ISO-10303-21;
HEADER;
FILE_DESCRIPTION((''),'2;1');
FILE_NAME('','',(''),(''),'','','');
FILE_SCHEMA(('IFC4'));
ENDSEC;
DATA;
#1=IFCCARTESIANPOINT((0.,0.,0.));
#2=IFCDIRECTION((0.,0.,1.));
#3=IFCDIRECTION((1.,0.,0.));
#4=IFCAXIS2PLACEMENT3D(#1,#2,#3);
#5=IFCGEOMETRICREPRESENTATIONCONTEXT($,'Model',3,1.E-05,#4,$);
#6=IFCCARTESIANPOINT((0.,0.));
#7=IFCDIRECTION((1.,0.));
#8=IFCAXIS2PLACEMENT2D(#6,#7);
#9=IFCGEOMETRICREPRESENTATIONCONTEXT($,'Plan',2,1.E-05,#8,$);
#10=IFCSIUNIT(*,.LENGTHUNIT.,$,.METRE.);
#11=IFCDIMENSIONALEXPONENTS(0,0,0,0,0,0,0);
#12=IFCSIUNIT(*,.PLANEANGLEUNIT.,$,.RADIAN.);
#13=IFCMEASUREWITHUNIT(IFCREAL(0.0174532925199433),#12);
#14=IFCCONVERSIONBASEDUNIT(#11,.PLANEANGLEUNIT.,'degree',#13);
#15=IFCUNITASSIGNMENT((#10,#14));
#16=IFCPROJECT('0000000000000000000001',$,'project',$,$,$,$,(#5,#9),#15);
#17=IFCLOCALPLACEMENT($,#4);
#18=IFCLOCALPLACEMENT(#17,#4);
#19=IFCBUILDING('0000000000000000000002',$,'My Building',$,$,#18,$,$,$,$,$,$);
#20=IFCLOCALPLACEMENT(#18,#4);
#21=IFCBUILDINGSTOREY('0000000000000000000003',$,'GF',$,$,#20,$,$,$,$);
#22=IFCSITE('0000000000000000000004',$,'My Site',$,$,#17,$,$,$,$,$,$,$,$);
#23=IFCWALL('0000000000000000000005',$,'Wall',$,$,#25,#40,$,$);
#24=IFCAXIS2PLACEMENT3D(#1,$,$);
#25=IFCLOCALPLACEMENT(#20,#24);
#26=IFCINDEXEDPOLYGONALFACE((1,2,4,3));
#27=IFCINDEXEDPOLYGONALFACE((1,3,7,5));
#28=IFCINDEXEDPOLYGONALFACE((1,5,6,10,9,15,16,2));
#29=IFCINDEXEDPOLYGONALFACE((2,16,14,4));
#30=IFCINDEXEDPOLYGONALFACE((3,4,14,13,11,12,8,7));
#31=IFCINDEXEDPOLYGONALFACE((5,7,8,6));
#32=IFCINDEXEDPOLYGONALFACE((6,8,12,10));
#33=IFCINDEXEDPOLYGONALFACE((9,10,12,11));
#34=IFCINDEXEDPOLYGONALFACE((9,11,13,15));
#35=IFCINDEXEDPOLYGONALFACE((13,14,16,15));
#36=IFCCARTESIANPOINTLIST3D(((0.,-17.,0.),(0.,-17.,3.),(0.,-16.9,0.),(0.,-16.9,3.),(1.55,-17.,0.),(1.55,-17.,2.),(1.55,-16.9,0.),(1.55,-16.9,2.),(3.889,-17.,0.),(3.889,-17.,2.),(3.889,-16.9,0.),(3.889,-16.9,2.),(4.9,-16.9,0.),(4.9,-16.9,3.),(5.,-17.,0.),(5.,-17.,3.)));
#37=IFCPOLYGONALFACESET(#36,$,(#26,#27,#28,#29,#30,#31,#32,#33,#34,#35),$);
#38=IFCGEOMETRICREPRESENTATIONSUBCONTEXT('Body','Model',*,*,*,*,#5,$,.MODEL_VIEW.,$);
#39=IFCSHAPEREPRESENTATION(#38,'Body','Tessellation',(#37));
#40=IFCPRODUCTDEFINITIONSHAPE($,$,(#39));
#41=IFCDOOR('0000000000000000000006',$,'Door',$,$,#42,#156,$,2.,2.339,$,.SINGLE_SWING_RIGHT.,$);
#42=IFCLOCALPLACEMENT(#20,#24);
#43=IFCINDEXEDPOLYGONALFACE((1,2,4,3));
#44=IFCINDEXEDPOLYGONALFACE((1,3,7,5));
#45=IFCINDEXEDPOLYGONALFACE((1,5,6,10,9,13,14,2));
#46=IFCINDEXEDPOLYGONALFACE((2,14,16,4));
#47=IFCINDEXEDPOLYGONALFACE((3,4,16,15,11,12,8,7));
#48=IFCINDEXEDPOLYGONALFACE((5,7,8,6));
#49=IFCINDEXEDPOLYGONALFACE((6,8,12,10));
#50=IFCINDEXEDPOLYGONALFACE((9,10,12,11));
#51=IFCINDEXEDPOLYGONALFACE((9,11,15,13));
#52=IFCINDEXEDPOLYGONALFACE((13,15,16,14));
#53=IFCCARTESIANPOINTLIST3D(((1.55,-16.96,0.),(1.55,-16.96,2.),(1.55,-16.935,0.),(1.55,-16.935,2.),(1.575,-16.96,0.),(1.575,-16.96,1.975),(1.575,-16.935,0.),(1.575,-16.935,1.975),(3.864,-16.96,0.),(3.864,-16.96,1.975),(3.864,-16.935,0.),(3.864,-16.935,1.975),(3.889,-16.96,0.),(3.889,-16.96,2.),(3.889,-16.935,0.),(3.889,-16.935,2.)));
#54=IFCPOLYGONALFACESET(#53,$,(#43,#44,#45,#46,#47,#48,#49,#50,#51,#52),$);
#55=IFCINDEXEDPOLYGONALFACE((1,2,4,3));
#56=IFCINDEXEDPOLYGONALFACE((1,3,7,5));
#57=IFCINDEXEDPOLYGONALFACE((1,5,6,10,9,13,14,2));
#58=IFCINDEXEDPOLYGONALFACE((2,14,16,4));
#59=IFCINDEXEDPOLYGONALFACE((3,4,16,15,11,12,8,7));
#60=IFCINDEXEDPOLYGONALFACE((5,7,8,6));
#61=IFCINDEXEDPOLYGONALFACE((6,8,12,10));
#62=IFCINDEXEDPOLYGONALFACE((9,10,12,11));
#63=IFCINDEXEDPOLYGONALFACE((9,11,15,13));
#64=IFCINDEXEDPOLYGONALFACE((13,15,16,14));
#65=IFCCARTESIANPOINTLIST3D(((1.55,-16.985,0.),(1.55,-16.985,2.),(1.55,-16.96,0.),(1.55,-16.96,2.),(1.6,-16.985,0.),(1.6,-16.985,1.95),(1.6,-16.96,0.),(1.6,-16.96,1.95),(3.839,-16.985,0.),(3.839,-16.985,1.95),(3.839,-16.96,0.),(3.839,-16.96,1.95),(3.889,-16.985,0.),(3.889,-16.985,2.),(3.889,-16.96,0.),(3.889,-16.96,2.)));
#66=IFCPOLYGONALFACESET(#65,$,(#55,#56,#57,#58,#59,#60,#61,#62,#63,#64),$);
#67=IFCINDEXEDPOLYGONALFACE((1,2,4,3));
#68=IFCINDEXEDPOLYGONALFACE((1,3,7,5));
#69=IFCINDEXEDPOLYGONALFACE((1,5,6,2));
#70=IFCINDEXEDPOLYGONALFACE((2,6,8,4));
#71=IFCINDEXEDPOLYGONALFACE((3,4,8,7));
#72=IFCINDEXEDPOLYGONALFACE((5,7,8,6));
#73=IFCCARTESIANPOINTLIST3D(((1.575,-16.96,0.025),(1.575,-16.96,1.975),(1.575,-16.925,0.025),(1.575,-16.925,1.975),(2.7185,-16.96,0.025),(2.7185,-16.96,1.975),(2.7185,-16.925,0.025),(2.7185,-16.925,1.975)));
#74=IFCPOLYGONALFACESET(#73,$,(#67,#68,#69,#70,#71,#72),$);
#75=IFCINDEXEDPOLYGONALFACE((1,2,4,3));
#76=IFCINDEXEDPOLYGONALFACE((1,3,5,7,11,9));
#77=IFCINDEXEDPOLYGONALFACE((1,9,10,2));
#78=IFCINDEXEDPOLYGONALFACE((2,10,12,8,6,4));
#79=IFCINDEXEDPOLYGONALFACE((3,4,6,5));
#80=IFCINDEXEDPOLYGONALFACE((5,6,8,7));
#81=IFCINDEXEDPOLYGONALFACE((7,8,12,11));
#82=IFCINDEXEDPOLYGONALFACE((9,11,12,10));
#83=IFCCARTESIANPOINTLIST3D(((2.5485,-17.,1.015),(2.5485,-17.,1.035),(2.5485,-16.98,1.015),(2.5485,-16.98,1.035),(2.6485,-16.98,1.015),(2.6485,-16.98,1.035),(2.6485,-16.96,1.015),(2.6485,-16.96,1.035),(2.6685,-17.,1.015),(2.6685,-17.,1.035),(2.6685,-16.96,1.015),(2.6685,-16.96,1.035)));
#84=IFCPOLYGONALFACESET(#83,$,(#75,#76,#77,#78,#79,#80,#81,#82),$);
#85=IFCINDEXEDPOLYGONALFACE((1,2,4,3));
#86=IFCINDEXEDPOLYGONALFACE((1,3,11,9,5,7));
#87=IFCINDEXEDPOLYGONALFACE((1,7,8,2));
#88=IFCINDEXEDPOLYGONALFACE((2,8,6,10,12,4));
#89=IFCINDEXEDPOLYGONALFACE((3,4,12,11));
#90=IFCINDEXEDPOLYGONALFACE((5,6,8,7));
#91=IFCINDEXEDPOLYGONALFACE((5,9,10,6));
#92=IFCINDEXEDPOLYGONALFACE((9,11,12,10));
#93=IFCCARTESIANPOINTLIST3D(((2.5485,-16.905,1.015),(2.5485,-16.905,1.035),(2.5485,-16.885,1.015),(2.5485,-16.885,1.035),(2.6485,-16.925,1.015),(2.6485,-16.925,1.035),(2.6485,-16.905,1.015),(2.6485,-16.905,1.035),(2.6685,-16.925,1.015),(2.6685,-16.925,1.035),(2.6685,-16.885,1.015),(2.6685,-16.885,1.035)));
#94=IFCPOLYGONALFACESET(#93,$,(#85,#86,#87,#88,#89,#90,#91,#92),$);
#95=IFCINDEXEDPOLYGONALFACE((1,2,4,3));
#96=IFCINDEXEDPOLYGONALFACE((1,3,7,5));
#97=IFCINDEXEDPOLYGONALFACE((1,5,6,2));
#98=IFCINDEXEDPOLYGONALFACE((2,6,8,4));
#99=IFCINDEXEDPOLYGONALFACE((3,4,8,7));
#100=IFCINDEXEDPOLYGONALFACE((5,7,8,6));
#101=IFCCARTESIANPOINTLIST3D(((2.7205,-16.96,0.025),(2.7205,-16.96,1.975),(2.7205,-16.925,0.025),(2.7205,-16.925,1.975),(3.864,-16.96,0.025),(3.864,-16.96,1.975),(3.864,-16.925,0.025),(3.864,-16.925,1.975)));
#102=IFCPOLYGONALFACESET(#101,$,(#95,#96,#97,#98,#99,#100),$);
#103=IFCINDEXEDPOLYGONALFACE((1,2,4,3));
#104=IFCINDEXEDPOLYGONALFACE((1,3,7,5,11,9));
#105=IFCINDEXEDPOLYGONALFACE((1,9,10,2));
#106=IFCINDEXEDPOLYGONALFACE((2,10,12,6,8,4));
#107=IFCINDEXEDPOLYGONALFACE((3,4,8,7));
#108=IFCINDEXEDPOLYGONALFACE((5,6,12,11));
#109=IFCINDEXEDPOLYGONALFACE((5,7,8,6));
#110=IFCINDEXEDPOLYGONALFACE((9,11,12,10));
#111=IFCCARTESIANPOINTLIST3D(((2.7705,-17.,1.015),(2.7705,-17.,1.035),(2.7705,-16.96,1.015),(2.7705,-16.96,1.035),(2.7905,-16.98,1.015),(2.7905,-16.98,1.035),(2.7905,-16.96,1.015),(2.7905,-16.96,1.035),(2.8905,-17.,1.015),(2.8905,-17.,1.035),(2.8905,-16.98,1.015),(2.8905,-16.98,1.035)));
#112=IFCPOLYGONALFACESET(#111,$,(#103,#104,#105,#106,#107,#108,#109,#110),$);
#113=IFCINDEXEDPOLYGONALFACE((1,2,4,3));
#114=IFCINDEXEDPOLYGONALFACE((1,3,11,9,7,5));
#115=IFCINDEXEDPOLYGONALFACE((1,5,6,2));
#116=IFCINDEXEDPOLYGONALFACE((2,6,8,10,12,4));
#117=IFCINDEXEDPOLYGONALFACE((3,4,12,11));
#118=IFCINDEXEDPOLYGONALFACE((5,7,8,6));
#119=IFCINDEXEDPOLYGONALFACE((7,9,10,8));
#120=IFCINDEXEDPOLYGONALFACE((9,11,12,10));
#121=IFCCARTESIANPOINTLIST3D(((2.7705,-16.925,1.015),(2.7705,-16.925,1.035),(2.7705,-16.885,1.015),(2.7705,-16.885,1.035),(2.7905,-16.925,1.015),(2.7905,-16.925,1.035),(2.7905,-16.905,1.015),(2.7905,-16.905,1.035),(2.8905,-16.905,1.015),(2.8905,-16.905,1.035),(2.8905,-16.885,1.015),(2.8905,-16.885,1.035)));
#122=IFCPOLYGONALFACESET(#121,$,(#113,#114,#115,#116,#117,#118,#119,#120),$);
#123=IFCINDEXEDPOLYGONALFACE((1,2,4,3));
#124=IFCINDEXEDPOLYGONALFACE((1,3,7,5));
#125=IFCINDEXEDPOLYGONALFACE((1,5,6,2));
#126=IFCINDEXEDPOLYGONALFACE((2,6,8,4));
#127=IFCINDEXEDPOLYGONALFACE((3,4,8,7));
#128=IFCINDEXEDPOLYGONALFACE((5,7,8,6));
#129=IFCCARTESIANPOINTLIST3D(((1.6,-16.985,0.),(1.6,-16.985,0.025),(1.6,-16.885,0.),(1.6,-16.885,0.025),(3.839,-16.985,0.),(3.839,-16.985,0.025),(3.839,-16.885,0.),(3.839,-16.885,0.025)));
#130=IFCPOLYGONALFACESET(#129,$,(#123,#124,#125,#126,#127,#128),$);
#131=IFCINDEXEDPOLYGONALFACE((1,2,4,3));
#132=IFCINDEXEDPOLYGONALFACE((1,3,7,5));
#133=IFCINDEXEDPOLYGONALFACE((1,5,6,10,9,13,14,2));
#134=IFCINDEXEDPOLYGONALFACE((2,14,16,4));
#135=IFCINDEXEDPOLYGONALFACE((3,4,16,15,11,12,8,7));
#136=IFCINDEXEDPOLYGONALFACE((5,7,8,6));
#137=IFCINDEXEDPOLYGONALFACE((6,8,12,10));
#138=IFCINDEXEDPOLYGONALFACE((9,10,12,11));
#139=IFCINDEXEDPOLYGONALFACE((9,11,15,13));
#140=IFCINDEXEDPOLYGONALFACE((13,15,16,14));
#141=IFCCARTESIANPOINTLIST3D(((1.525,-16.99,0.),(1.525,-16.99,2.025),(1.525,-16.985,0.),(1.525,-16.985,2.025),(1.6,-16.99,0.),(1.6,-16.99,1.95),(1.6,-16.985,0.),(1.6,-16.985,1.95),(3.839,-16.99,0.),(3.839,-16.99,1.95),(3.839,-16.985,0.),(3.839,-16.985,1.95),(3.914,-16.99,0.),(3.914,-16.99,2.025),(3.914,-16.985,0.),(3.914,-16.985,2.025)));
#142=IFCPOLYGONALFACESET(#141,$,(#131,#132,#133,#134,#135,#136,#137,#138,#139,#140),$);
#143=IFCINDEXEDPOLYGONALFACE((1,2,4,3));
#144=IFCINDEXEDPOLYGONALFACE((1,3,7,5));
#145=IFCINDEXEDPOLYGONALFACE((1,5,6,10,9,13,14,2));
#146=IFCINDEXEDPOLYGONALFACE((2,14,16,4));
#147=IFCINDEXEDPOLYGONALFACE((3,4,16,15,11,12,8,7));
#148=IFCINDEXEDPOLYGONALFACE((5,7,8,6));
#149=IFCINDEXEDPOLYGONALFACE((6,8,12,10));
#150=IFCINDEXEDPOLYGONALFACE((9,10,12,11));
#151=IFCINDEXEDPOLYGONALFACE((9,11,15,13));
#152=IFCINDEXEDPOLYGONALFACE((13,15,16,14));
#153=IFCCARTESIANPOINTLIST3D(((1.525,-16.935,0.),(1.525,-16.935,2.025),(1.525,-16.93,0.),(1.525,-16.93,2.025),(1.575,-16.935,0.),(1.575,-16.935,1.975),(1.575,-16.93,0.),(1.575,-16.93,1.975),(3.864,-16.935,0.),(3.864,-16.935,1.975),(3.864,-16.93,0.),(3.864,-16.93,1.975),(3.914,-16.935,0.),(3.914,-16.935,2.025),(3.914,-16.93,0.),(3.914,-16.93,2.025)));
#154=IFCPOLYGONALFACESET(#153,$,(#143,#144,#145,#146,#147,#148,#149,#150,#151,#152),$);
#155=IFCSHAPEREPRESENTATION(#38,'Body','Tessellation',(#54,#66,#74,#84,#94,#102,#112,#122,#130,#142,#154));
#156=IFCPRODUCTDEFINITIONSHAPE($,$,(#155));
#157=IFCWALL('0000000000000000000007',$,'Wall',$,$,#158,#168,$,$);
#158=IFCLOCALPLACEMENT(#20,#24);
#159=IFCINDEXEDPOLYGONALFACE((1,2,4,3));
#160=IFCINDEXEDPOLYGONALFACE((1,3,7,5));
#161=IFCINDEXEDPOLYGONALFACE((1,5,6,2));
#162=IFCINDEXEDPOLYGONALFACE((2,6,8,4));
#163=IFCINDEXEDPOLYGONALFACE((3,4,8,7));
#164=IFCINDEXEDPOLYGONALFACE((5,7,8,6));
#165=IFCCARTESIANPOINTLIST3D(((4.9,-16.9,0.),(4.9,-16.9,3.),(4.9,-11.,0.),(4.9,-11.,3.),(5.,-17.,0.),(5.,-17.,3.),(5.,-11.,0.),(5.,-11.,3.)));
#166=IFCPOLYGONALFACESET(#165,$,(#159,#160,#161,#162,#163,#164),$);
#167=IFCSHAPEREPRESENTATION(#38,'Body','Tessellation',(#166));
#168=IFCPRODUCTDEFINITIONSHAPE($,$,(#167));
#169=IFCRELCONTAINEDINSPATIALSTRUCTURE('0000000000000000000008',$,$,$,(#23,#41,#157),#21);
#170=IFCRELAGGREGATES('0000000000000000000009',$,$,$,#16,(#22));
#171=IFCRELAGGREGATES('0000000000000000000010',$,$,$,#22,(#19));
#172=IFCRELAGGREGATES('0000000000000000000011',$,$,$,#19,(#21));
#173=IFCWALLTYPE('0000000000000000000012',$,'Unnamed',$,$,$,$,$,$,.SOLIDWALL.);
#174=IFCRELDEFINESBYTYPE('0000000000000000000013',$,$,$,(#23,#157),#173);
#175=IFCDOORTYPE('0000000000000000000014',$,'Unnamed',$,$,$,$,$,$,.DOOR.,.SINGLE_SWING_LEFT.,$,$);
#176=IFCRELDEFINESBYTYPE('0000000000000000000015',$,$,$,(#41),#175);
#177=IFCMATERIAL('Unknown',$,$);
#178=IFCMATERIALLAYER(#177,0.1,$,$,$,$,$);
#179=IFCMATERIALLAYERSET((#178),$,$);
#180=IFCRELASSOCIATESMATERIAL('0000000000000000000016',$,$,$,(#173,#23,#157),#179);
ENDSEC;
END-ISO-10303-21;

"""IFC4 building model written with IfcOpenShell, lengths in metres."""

from ifc_helpers import new_model, entity, si_unit, converted_unit, frame, origin_with_axes, origin_2d_with_axis, place, context, subcontext, project, spatial, line, indexed_curve, outline, extrude, shape, source, transform, mapped, material, layer, layer_set, layer_usage, type_object, type_shapes, element, fill, save


model = new_model("IFC4")

# Units and contexts
model_context = context("Model", 3, precision=1e-05, world=origin_with_axes())
plan_context = context("Plan", 2, precision=1e-05, world=origin_2d_with_axis())
body_context_1 = subcontext(model_context, "Body", "Model", "MODEL_VIEW")
body_context_2 = subcontext(plan_context, "Body", "Plan", "PLAN_VIEW")
ifc_project = project(units=[si_unit("LENGTHUNIT", "METRE"), converted_unit("PLANEANGLEUNIT", "degree", entity("IfcReal", 0.0174532925199433), si_unit("PLANEANGLEUNIT", "RADIAN"), dimensions=[0, 0, 0, 0, 0, 0, 0])], contexts=[model_context, plan_context])

# Site, building, storey
site_placement = place(None, origin_with_axes())
site = spatial("IfcSite", under=ifc_project, at=site_placement, Name="My Site")
building_placement = place(site_placement, origin_with_axes())
building = spatial("IfcBuilding", under=site, at=building_placement, Name="My Building")
storey_placement = place(building_placement, origin_with_axes())
storey = spatial("IfcBuildingStorey", under=building, at=storey_placement, Name="GF")

# Shared definitions
ifc_material = material(Name="Unknown")

# Shared definitions
ifc_layer_1 = layer(ifc_material, 0.1)
ifc_layer_set_1 = layer_set([ifc_layer_1])
wall_type = type_object("IfcWallType", Name="Unnamed", PredefinedType="SOLIDWALL", material=ifc_layer_set_1)

# Wall, opening, door
ifc_layer_usage_1 = layer_usage(ifc_layer_set_1, "AXIS2", "POSITIVE", 0.0)
wall_1_placement = place(storey_placement, frame((0.0, -17.0, 0.0), z_axis=(0.0, 0.0, 1.0), x_axis=(1.0, 0.0, 0.0)))
wall_1 = element("IfcWall", 1, at=wall_1_placement, inside=storey, type_object=wall_type, material=ifc_layer_usage_1, Name="Wall", context=body_context_1, shape_type="SweptSolid", body=[
    extrude(outline(indexed_curve([(0.0, 0.0), (0.0, 0.1), (4.9, 0.1), (5.0, 0.0)], segments=[line(1, 2, 3, 4, 1)])), origin_with_axes(), (0.0, 0.0, 1.0), 3.0),
])
shared_shape_1 = source(origin_with_axes(), body_context_1, "Body", "SweptSolid", [
    extrude(outline(indexed_curve([(0.0, 0.0), (2.339, 0.0), (2.339, 2.0), (0.0, 2.0)], segments=[line(1, 2, 3, 4, 1)])), frame((0.0, -0.6, 0.0), z_axis=(0.0, -1.0, 0.0), x_axis=(1.0, 0.0, 0.0)), (0.0, 0.0, -1.0), 1.2),
])
opening_1_placement = place(wall_1_placement, frame((1.55, 0.015, 0.0), z_axis=(0.0, 0.0, 1.0), x_axis=(1.0, 0.0, 0.0)))
opening_1 = element("IfcOpeningElement", 2, at=opening_1_placement, cuts=wall_1, PredefinedType="OPENING", context=body_context_1, shape_type="MappedRepresentation", body=[
    mapped(shared_shape_1, transform((0.0, 0.0, 0.0), x_axis=(1.0, 0.0, 0.0), y_axis=(0.0, 1.0, 0.0), z_axis=(0.0, 0.0, 1.0), scale=1.0)),
])
door_type_1 = type_object("IfcDoorType", Name="Unnamed", OperationType="SINGLE_SWING_LEFT", PredefinedType="DOOR")
shared_shape_2 = source(origin_with_axes(), body_context_1, "Body", "SweptSolid", [
    extrude(outline(indexed_curve([(0.0, 0.0), (0.0, 2.0), (2.339, 2.0), (2.339, 0.0), (2.314, 0.0), (2.314, 1.975), (0.025, 1.975), (0.025, 0.0)], segments=[line(1, 2, 3, 4, 5, 6, 7, 8, 1)])), frame((0.0, 0.025, 0.0), z_axis=(0.0, -1.0, 0.0), x_axis=(1.0, 0.0, 0.0)), (0.0, 0.0, -1.0), 0.025),
    extrude(outline(indexed_curve([(0.0, 0.0), (0.0, 2.0), (2.339, 2.0), (2.339, 0.0), (2.289, 0.0), (2.289, 1.95), (0.05, 1.95), (0.05, 0.0)], segments=[line(1, 2, 3, 4, 5, 6, 7, 8, 1)])), frame((0.0, 0.0, 0.0), z_axis=(0.0, -1.0, 0.0), x_axis=(1.0, 0.0, 0.0)), (0.0, 0.0, -1.0), 0.025),
    extrude(outline(indexed_curve([(0.0, 0.0), (1.1435, 0.0), (1.1435, 0.035), (0.0, 0.035)], segments=[line(1, 2, 3, 4, 1)])), frame((0.025, 0.025, 0.025), z_axis=(0.0, 0.0, 1.0), x_axis=(1.0, 0.0, 0.0)), (0.0, 0.0, 1.0), 1.95),
    extrude(outline(indexed_curve([(0.0, 0.0), (0.0, -0.04), (-0.12, -0.04), (-0.12, -0.02), (-0.02, -0.02), (-0.02, 0.0)], segments=[line(1, 2, 3, 4, 5, 6, 1)])), frame((1.1185, 0.025, 1.015), z_axis=(0.0, 0.0, 1.0), x_axis=(1.0, 0.0, 0.0)), (0.0, 0.0, 1.0), 0.02),
    extrude(outline(indexed_curve([(0.0, 0.0), (0.0, 0.04), (-0.12, 0.04), (-0.12, 0.02), (-0.02, 0.02), (-0.02, 0.0)], segments=[line(1, 2, 3, 4, 5, 6, 1)])), frame((1.1185, 0.06, 1.015), z_axis=(0.0, 0.0, 1.0), x_axis=(1.0, 0.0, 0.0)), (0.0, 0.0, 1.0), 0.02),
    extrude(outline(indexed_curve([(0.0, 0.0), (-1.1435, 0.0), (-1.1435, 0.035), (0.0, 0.035)], segments=[line(1, 2, 3, 4, 1)])), frame((2.314, 0.025, 0.025), z_axis=(0.0, 0.0, 1.0), x_axis=(1.0, 0.0, 0.0)), (0.0, 0.0, 1.0), 1.95),
    extrude(outline(indexed_curve([(0.0, 0.0), (0.0, -0.04), (0.12, -0.04), (0.12, -0.02), (0.02, -0.02), (0.02, 0.0)], segments=[line(1, 2, 3, 4, 5, 6, 1)])), frame((1.2205, 0.025, 1.015), z_axis=(0.0, 0.0, 1.0), x_axis=(1.0, 0.0, 0.0)), (0.0, 0.0, 1.0), 0.02),
    extrude(outline(indexed_curve([(0.0, 0.0), (0.0, 0.04), (0.12, 0.04), (0.12, 0.02), (0.02, 0.02), (0.02, 0.0)], segments=[line(1, 2, 3, 4, 5, 6, 1)])), frame((1.2205, 0.06, 1.015), z_axis=(0.0, 0.0, 1.0), x_axis=(1.0, 0.0, 0.0)), (0.0, 0.0, 1.0), 0.02),
    extrude(outline(indexed_curve([(0.0, 0.0), (2.239, 0.0), (2.239, 0.1), (0.0, 0.1)], segments=[line(1, 2, 3, 4, 1)])), frame((0.05, 0.0, 0.0), z_axis=(0.0, 0.0, 1.0), x_axis=(1.0, 0.0, 0.0)), (0.0, 0.0, 1.0), 0.025),
    extrude(outline(indexed_curve([(0.0, 0.0), (0.0, 2.025), (2.389, 2.025), (2.389, 0.0), (2.314, 0.0), (2.314, 1.95), (0.075, 1.95), (0.075, 0.0)], segments=[line(1, 2, 3, 4, 5, 6, 7, 8, 1)])), frame((-0.025, -0.005, 0.0), z_axis=(0.0, -1.0, 0.0), x_axis=(1.0, 0.0, 0.0)), (0.0, 0.0, -1.0), 0.005),
    extrude(outline(indexed_curve([(0.0, 0.0), (0.0, 2.025), (2.389, 2.025), (2.389, 0.0), (2.339, 0.0), (2.339, 1.975), (0.05, 1.975), (0.05, 0.0)], segments=[line(1, 2, 3, 4, 5, 6, 7, 8, 1)])), frame((-0.025, 0.05, 0.0), z_axis=(0.0, -1.0, 0.0), x_axis=(1.0, 0.0, 0.0)), (0.0, 0.0, -1.0), 0.005),
])
shared_shape_3 = source(origin_with_axes(), body_context_2, "Body", "Curve2D", [
    entity("IfcIndexedPolyCurve", entity("IfcCartesianPointList2D", [[0.0, 0.0], [0.0, 0.05], [0.025, 0.05], [0.025, 0.025], [0.05, 0.025], [0.05, 0.0]]), [entity("IfcLineIndex", [1, 2, 3, 4, 5, 6, 1])]),
    entity("IfcIndexedPolyCurve", entity("IfcCartesianPointList2D", [[2.339, 0.0], [2.339, 0.05], [2.314, 0.05], [2.314, 0.025], [2.289, 0.025], [2.289, 0.0]]), [entity("IfcLineIndex", [1, 2, 3, 4, 5, 6, 1])]),
    entity("IfcTrimmedCurve", entity("IfcEllipse", entity("IfcAxis2Placement2D", entity("IfcCartesianPoint", [0.06, 0.05]), entity("IfcDirection", [1.0, 0.0])), 1.1095, 1.1445), [entity("IfcCartesianPoint", [1.1695, 0.05])], [entity("IfcCartesianPoint", [0.06, 1.1945])], True, "CARTESIAN"),
    entity("IfcIndexedPolyCurve", entity("IfcCartesianPointList2D", [[0.025, 0.05], [0.06, 0.05], [0.06, 1.1945], [0.025, 1.1945]]), [entity("IfcLineIndex", [1, 2, 3, 4, 1])]),
    entity("IfcTrimmedCurve", entity("IfcEllipse", entity("IfcAxis2Placement2D", entity("IfcCartesianPoint", [2.279, 0.05]), entity("IfcDirection", [1.0, 0.0])), 1.1095, 1.1445), [entity("IfcCartesianPoint", [2.279, 1.1945])], [entity("IfcCartesianPoint", [1.1695, 0.05])], True, "CARTESIAN"),
    entity("IfcIndexedPolyCurve", entity("IfcCartesianPointList2D", [[2.314, 0.05], [2.279, 0.05], [2.279, 1.1945], [2.314, 1.1945]]), [entity("IfcLineIndex", [1, 2, 3, 4, 1])]),
])
type_shapes(door_type_1, [shared_shape_2, shared_shape_3])
door_1_placement = place(opening_1_placement, frame((0.0, 0.0, 0.0), z_axis=(0.0, 0.0, 1.0), x_axis=(1.0, 0.0, 0.0)))
door_1 = element("IfcDoor", 3, at=door_1_placement, inside=storey, type_object=door_type_1, Name="Door", OperationType="SINGLE_SWING_RIGHT", OverallHeight=2.0, OverallWidth=2.339, shapes=[
    shape(body_context_1, "Body", "MappedRepresentation", [mapped(shared_shape_2, transform((0.0, 0.0, 0.0), x_axis=(1.0, 0.0, 0.0), y_axis=(0.0, 1.0, 0.0), z_axis=(0.0, 0.0, 1.0), scale=1.0))]),
    shape(body_context_2, "Body", "MappedRepresentation", [mapped(shared_shape_3, transform((0.0, 0.0, 0.0), x_axis=(1.0, 0.0, 0.0), y_axis=(0.0, 1.0, 0.0), z_axis=(0.0, 0.0, 1.0), scale=1.0))]),
])
fill(opening_1, door_1)

# Wall
ifc_layer_usage_2 = layer_usage(ifc_layer_set_1, "AXIS2", "POSITIVE", 0.0)
wall_2_placement = place(storey_placement, frame((5.0, -17.0, 0.0), z_axis=(0.0, 0.0, 1.0), x_axis=(0.0, 1.0, 0.0)))
element("IfcWall", 4, at=wall_2_placement, inside=storey, type_object=wall_type, material=ifc_layer_usage_2, Name="Wall", context=body_context_1, shape_type="SweptSolid", body=[
    extrude(outline(indexed_curve([(0.0, 0.0), (0.1, 0.1), (6.0, 0.1), (6.0, 0.0)], segments=[line(1, 2, 3, 4, 1)])), origin_with_axes(), (0.0, 0.0, 1.0), 3.0),
])

save(model, "model.ifc")
